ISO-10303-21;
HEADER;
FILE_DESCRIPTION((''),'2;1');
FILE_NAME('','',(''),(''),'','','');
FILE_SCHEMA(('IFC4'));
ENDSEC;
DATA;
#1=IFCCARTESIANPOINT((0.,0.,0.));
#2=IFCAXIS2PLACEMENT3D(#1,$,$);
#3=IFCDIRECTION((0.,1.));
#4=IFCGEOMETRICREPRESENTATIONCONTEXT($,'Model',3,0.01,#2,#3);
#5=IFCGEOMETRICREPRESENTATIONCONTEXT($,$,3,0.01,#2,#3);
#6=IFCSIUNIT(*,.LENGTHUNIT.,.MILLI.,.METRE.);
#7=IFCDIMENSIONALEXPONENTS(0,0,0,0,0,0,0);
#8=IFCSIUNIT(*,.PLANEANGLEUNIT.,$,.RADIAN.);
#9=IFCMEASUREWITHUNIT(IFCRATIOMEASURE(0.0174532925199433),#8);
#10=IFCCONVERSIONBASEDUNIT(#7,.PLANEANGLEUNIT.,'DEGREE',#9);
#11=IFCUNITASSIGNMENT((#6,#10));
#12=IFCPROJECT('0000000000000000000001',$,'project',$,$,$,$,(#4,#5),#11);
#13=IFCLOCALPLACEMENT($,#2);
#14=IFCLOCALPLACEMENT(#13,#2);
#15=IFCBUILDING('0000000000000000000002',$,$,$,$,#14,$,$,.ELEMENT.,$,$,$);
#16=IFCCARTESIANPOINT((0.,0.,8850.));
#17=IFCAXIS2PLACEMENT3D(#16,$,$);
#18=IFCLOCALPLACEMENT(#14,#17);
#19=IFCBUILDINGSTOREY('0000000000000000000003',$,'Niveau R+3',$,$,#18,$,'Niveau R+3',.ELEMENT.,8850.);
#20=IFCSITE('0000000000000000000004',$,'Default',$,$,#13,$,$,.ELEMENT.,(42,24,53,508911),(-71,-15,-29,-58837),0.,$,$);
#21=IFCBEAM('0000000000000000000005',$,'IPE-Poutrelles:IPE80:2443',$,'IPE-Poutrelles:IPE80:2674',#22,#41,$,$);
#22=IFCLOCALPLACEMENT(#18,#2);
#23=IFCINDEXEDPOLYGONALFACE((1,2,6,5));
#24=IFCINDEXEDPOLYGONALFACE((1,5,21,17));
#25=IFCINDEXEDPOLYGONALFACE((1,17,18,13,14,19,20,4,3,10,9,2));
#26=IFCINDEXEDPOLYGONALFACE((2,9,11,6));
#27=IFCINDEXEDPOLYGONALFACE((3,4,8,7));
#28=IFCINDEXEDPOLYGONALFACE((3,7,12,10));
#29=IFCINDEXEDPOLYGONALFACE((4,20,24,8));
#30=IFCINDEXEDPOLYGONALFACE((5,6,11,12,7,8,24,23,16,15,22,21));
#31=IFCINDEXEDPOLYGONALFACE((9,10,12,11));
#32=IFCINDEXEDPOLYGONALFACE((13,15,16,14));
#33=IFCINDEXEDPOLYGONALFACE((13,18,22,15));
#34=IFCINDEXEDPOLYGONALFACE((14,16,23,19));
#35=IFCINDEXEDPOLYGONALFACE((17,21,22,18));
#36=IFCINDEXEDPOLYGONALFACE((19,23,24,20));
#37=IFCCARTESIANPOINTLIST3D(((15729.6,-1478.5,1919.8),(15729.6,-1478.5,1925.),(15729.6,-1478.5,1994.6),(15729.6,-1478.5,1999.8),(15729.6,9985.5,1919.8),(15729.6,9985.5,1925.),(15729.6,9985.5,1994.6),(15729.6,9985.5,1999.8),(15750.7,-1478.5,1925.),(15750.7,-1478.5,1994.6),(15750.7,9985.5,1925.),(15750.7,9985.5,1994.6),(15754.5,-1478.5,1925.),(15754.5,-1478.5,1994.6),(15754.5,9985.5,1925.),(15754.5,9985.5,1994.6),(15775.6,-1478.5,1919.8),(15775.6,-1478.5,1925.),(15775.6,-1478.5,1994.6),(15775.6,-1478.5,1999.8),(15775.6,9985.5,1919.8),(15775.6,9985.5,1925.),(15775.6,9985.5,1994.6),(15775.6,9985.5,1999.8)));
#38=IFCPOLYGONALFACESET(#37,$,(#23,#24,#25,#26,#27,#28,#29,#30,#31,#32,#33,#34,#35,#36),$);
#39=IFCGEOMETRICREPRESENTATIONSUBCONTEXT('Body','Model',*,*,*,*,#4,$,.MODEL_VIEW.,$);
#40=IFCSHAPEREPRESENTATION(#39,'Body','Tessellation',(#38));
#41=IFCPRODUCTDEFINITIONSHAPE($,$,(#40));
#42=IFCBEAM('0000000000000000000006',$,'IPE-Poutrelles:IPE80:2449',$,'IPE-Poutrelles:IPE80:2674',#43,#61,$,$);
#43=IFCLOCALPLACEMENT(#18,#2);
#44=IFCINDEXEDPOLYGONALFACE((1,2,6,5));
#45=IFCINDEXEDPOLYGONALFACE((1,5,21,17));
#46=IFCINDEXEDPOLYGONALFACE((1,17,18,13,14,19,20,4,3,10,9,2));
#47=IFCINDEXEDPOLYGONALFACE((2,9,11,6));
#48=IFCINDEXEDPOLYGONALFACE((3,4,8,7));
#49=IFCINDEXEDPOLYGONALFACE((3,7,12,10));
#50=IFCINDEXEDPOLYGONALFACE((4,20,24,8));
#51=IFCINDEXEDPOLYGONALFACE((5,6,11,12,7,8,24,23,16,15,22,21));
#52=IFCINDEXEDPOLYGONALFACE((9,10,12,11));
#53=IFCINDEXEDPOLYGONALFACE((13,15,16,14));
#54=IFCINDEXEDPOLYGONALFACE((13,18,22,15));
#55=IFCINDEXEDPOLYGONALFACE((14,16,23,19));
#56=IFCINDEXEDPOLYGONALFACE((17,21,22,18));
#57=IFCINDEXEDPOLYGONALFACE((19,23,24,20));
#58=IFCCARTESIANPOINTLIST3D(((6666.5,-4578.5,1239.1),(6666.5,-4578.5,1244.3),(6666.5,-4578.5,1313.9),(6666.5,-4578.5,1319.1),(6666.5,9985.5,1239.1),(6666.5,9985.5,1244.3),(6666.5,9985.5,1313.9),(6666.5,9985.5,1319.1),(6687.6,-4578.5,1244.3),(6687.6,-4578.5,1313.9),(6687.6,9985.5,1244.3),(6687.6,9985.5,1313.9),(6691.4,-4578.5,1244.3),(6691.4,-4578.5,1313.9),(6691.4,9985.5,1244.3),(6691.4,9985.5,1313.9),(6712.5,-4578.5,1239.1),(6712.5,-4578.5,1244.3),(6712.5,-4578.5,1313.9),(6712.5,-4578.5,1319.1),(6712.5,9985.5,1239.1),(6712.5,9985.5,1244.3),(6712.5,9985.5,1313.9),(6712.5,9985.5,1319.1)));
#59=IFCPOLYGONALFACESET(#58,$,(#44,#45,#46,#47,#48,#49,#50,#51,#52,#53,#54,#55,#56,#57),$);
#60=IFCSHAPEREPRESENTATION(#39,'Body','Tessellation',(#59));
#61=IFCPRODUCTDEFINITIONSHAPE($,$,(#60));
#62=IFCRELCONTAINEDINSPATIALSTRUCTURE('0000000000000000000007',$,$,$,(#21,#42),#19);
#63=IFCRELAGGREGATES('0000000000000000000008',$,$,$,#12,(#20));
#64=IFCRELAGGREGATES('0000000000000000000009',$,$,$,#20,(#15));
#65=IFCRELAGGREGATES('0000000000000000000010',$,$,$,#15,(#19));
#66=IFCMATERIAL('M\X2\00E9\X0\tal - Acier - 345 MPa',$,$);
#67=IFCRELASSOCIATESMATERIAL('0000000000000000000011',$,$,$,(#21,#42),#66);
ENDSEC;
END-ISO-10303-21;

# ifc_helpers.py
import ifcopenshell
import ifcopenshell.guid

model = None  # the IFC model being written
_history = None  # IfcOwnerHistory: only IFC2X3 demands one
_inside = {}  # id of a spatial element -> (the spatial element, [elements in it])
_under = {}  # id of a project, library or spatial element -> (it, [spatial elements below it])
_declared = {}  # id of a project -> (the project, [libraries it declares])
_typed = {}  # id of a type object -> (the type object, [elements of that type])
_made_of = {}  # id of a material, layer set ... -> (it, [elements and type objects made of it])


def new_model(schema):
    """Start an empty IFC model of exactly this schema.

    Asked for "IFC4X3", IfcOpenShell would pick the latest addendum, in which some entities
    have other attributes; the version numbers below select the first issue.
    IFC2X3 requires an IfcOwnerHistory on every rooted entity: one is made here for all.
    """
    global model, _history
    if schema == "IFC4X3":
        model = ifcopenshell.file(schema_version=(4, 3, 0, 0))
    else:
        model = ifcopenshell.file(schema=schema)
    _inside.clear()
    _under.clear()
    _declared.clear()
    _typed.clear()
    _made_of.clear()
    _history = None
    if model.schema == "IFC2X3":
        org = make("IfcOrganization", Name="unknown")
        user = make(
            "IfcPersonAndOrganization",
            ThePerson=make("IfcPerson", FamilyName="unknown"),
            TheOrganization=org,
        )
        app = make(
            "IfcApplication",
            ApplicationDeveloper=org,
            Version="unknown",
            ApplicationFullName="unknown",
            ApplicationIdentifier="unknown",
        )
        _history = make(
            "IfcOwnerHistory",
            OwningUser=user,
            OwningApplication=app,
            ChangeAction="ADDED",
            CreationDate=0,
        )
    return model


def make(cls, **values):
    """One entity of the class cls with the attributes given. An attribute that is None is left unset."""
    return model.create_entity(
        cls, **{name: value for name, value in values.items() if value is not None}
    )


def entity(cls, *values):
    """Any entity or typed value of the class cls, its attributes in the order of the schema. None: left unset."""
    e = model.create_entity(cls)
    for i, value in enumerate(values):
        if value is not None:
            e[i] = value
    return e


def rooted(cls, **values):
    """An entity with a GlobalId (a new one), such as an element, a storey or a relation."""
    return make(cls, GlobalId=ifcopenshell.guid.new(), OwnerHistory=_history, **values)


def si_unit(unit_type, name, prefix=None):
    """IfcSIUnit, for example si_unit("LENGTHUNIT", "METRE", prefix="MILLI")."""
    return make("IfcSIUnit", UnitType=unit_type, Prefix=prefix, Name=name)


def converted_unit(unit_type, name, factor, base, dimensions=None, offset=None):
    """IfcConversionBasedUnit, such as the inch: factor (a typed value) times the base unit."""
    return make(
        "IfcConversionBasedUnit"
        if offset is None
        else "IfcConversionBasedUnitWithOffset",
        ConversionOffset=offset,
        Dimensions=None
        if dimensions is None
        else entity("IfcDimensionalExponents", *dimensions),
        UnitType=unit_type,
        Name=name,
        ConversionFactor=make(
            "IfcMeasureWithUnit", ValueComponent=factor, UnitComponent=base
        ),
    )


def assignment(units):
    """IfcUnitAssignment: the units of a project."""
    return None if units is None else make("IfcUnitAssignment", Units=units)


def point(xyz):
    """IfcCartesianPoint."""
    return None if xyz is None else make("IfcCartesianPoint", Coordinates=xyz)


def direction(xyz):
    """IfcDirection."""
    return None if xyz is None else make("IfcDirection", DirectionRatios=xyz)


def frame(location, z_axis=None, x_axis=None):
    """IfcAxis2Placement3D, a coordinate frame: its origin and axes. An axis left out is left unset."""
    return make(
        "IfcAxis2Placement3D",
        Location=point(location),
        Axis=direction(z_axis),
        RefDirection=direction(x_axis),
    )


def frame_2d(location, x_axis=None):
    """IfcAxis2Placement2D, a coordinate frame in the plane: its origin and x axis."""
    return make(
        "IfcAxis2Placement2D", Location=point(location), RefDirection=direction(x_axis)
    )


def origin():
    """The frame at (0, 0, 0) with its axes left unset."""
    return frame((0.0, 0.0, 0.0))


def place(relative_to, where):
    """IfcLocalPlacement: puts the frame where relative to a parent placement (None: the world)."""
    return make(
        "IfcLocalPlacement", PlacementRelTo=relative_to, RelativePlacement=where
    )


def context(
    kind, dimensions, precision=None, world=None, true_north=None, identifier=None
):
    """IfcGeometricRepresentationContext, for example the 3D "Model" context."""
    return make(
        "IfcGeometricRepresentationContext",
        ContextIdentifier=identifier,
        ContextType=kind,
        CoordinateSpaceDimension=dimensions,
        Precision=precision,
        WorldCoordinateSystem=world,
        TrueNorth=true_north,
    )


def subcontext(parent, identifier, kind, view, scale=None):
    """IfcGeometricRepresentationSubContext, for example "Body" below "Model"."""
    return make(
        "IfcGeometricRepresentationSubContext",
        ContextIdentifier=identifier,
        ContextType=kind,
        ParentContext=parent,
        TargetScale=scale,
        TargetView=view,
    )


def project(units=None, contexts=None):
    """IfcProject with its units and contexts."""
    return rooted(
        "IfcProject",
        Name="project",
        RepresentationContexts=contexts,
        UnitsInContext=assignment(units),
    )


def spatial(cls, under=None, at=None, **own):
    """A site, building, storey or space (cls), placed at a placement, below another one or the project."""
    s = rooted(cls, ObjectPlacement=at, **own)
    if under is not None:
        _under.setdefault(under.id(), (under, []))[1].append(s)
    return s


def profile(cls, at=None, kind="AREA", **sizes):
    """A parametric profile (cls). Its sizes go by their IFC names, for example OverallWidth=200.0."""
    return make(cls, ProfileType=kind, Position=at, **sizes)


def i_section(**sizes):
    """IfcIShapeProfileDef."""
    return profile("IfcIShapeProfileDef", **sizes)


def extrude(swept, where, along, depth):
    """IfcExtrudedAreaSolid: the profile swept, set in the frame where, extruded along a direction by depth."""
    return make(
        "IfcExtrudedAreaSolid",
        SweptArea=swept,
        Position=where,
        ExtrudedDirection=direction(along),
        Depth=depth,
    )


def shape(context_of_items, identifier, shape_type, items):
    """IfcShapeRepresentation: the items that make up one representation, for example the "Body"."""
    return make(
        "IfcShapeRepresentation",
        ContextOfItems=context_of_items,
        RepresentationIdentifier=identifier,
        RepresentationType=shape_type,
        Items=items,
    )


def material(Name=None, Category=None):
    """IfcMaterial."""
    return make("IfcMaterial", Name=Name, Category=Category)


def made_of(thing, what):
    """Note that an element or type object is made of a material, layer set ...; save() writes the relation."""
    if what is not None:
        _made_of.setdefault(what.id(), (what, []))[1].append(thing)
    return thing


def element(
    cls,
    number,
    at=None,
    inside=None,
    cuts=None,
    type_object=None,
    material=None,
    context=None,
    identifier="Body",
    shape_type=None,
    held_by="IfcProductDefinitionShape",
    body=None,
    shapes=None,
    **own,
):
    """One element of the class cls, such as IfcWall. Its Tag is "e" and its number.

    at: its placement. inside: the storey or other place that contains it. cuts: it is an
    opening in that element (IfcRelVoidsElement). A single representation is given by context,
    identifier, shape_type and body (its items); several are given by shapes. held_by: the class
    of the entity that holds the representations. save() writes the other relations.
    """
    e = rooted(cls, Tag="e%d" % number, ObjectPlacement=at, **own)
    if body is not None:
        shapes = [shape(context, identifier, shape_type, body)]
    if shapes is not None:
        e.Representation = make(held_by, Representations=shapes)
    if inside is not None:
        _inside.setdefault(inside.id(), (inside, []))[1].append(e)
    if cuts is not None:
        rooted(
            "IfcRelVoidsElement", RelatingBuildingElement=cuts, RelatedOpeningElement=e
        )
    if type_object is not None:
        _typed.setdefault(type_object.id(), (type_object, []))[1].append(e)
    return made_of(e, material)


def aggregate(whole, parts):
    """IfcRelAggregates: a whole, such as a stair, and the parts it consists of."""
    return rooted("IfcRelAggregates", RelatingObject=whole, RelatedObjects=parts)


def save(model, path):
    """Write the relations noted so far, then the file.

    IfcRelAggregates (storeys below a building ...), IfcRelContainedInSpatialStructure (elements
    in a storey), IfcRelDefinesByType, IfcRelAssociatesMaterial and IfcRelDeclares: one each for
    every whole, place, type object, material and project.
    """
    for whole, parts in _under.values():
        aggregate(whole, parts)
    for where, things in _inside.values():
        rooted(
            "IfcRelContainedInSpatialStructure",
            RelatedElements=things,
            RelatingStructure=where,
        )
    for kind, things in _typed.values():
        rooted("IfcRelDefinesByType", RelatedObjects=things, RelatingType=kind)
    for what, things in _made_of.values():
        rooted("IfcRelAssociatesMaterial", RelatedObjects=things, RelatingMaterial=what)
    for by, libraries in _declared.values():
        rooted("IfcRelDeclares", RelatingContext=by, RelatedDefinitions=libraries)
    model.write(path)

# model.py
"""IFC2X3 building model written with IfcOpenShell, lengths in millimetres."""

from ifc_helpers import new_model, entity, si_unit, converted_unit, direction, frame, frame_2d, origin, place, context, subcontext, project, spatial, i_section, extrude, material, element, save


model = new_model("IFC2X3")

# Units and contexts
model_context = context("Model", 3, precision=0.01, world=origin(), true_north=direction((0.0, 1.0)))
context_of_model = context(None, 3, precision=0.01, world=origin(), true_north=direction((0.0, 1.0)))
body_context = subcontext(model_context, "Body", "Model", "MODEL_VIEW")
ifc_project = project(units=[si_unit("LENGTHUNIT", "METRE", prefix="MILLI"), converted_unit("PLANEANGLEUNIT", "DEGREE", entity("IfcRatioMeasure", 0.0174532925199433), si_unit("PLANEANGLEUNIT", "RADIAN"), dimensions=[0, 0, 0, 0, 0, 0, 0])], contexts=[model_context, context_of_model])

# Site, building, storey
site_placement = place(None, origin())
site = spatial("IfcSite", under=ifc_project, at=site_placement, Name="Default", CompositionType="ELEMENT", RefLatitude=(42, 24, 53, 508911), RefLongitude=(-71, -15, -29, -58837), RefElevation=0.0)
building_placement = place(site_placement, origin())
building = spatial("IfcBuilding", under=site, at=building_placement, CompositionType="ELEMENT")
storey_placement = place(building_placement, frame((0.0, 0.0, 8850.0)))
storey = spatial("IfcBuildingStorey", under=building, at=storey_placement, Name="Niveau R+3", LongName="Niveau R+3", CompositionType="ELEMENT", Elevation=8850.0)

# Shared definitions
ifc_material = material(Name="Métal - Acier - 345 MPa")

# Beams
beam_1_placement = place(storey_placement, frame((15752.6, 9985.5, 1999.8), z_axis=(0.0, 0.0, 1.0), x_axis=(0.0, -1.0, 0.0)))
element("IfcBeam", 1, at=beam_1_placement, inside=storey, material=ifc_material, Name="IPE-Poutrelles:IPE80:2443", ObjectType="IPE-Poutrelles:IPE80:2674", context=body_context, shape_type="SweptSolid", body=[
    extrude(i_section(OverallWidth=46.0, OverallDepth=80.0, WebThickness=3.8, FlangeThickness=5.2, at=frame_2d((0.0, 0.0), x_axis=(0.0, 1.0))), frame((0.0, 0.0, -40.0), z_axis=(1.0, 0.0, 0.0), x_axis=(0.0, 0.0, -1.0)), (0.0, 0.0, 1.0), 11464.0),
])
beam_2_placement = place(storey_placement, frame((6689.5, 9985.5, 1319.1), z_axis=(0.0, 0.0, 1.0), x_axis=(0.0, -1.0, 0.0)))
element("IfcBeam", 2, at=beam_2_placement, inside=storey, material=ifc_material, Name="IPE-Poutrelles:IPE80:2449", ObjectType="IPE-Poutrelles:IPE80:2674", context=body_context, shape_type="SweptSolid", body=[
    extrude(i_section(OverallWidth=46.0, OverallDepth=80.0, WebThickness=3.8, FlangeThickness=5.2, at=frame_2d((0.0, 0.0), x_axis=(0.0, 1.0))), frame((0.0, 0.0, -40.0), z_axis=(1.0, 0.0, 0.0), x_axis=(0.0, 0.0, -1.0)), (0.0, 0.0, 1.0), 14564.0),
])

save(model, "model.ifc")
